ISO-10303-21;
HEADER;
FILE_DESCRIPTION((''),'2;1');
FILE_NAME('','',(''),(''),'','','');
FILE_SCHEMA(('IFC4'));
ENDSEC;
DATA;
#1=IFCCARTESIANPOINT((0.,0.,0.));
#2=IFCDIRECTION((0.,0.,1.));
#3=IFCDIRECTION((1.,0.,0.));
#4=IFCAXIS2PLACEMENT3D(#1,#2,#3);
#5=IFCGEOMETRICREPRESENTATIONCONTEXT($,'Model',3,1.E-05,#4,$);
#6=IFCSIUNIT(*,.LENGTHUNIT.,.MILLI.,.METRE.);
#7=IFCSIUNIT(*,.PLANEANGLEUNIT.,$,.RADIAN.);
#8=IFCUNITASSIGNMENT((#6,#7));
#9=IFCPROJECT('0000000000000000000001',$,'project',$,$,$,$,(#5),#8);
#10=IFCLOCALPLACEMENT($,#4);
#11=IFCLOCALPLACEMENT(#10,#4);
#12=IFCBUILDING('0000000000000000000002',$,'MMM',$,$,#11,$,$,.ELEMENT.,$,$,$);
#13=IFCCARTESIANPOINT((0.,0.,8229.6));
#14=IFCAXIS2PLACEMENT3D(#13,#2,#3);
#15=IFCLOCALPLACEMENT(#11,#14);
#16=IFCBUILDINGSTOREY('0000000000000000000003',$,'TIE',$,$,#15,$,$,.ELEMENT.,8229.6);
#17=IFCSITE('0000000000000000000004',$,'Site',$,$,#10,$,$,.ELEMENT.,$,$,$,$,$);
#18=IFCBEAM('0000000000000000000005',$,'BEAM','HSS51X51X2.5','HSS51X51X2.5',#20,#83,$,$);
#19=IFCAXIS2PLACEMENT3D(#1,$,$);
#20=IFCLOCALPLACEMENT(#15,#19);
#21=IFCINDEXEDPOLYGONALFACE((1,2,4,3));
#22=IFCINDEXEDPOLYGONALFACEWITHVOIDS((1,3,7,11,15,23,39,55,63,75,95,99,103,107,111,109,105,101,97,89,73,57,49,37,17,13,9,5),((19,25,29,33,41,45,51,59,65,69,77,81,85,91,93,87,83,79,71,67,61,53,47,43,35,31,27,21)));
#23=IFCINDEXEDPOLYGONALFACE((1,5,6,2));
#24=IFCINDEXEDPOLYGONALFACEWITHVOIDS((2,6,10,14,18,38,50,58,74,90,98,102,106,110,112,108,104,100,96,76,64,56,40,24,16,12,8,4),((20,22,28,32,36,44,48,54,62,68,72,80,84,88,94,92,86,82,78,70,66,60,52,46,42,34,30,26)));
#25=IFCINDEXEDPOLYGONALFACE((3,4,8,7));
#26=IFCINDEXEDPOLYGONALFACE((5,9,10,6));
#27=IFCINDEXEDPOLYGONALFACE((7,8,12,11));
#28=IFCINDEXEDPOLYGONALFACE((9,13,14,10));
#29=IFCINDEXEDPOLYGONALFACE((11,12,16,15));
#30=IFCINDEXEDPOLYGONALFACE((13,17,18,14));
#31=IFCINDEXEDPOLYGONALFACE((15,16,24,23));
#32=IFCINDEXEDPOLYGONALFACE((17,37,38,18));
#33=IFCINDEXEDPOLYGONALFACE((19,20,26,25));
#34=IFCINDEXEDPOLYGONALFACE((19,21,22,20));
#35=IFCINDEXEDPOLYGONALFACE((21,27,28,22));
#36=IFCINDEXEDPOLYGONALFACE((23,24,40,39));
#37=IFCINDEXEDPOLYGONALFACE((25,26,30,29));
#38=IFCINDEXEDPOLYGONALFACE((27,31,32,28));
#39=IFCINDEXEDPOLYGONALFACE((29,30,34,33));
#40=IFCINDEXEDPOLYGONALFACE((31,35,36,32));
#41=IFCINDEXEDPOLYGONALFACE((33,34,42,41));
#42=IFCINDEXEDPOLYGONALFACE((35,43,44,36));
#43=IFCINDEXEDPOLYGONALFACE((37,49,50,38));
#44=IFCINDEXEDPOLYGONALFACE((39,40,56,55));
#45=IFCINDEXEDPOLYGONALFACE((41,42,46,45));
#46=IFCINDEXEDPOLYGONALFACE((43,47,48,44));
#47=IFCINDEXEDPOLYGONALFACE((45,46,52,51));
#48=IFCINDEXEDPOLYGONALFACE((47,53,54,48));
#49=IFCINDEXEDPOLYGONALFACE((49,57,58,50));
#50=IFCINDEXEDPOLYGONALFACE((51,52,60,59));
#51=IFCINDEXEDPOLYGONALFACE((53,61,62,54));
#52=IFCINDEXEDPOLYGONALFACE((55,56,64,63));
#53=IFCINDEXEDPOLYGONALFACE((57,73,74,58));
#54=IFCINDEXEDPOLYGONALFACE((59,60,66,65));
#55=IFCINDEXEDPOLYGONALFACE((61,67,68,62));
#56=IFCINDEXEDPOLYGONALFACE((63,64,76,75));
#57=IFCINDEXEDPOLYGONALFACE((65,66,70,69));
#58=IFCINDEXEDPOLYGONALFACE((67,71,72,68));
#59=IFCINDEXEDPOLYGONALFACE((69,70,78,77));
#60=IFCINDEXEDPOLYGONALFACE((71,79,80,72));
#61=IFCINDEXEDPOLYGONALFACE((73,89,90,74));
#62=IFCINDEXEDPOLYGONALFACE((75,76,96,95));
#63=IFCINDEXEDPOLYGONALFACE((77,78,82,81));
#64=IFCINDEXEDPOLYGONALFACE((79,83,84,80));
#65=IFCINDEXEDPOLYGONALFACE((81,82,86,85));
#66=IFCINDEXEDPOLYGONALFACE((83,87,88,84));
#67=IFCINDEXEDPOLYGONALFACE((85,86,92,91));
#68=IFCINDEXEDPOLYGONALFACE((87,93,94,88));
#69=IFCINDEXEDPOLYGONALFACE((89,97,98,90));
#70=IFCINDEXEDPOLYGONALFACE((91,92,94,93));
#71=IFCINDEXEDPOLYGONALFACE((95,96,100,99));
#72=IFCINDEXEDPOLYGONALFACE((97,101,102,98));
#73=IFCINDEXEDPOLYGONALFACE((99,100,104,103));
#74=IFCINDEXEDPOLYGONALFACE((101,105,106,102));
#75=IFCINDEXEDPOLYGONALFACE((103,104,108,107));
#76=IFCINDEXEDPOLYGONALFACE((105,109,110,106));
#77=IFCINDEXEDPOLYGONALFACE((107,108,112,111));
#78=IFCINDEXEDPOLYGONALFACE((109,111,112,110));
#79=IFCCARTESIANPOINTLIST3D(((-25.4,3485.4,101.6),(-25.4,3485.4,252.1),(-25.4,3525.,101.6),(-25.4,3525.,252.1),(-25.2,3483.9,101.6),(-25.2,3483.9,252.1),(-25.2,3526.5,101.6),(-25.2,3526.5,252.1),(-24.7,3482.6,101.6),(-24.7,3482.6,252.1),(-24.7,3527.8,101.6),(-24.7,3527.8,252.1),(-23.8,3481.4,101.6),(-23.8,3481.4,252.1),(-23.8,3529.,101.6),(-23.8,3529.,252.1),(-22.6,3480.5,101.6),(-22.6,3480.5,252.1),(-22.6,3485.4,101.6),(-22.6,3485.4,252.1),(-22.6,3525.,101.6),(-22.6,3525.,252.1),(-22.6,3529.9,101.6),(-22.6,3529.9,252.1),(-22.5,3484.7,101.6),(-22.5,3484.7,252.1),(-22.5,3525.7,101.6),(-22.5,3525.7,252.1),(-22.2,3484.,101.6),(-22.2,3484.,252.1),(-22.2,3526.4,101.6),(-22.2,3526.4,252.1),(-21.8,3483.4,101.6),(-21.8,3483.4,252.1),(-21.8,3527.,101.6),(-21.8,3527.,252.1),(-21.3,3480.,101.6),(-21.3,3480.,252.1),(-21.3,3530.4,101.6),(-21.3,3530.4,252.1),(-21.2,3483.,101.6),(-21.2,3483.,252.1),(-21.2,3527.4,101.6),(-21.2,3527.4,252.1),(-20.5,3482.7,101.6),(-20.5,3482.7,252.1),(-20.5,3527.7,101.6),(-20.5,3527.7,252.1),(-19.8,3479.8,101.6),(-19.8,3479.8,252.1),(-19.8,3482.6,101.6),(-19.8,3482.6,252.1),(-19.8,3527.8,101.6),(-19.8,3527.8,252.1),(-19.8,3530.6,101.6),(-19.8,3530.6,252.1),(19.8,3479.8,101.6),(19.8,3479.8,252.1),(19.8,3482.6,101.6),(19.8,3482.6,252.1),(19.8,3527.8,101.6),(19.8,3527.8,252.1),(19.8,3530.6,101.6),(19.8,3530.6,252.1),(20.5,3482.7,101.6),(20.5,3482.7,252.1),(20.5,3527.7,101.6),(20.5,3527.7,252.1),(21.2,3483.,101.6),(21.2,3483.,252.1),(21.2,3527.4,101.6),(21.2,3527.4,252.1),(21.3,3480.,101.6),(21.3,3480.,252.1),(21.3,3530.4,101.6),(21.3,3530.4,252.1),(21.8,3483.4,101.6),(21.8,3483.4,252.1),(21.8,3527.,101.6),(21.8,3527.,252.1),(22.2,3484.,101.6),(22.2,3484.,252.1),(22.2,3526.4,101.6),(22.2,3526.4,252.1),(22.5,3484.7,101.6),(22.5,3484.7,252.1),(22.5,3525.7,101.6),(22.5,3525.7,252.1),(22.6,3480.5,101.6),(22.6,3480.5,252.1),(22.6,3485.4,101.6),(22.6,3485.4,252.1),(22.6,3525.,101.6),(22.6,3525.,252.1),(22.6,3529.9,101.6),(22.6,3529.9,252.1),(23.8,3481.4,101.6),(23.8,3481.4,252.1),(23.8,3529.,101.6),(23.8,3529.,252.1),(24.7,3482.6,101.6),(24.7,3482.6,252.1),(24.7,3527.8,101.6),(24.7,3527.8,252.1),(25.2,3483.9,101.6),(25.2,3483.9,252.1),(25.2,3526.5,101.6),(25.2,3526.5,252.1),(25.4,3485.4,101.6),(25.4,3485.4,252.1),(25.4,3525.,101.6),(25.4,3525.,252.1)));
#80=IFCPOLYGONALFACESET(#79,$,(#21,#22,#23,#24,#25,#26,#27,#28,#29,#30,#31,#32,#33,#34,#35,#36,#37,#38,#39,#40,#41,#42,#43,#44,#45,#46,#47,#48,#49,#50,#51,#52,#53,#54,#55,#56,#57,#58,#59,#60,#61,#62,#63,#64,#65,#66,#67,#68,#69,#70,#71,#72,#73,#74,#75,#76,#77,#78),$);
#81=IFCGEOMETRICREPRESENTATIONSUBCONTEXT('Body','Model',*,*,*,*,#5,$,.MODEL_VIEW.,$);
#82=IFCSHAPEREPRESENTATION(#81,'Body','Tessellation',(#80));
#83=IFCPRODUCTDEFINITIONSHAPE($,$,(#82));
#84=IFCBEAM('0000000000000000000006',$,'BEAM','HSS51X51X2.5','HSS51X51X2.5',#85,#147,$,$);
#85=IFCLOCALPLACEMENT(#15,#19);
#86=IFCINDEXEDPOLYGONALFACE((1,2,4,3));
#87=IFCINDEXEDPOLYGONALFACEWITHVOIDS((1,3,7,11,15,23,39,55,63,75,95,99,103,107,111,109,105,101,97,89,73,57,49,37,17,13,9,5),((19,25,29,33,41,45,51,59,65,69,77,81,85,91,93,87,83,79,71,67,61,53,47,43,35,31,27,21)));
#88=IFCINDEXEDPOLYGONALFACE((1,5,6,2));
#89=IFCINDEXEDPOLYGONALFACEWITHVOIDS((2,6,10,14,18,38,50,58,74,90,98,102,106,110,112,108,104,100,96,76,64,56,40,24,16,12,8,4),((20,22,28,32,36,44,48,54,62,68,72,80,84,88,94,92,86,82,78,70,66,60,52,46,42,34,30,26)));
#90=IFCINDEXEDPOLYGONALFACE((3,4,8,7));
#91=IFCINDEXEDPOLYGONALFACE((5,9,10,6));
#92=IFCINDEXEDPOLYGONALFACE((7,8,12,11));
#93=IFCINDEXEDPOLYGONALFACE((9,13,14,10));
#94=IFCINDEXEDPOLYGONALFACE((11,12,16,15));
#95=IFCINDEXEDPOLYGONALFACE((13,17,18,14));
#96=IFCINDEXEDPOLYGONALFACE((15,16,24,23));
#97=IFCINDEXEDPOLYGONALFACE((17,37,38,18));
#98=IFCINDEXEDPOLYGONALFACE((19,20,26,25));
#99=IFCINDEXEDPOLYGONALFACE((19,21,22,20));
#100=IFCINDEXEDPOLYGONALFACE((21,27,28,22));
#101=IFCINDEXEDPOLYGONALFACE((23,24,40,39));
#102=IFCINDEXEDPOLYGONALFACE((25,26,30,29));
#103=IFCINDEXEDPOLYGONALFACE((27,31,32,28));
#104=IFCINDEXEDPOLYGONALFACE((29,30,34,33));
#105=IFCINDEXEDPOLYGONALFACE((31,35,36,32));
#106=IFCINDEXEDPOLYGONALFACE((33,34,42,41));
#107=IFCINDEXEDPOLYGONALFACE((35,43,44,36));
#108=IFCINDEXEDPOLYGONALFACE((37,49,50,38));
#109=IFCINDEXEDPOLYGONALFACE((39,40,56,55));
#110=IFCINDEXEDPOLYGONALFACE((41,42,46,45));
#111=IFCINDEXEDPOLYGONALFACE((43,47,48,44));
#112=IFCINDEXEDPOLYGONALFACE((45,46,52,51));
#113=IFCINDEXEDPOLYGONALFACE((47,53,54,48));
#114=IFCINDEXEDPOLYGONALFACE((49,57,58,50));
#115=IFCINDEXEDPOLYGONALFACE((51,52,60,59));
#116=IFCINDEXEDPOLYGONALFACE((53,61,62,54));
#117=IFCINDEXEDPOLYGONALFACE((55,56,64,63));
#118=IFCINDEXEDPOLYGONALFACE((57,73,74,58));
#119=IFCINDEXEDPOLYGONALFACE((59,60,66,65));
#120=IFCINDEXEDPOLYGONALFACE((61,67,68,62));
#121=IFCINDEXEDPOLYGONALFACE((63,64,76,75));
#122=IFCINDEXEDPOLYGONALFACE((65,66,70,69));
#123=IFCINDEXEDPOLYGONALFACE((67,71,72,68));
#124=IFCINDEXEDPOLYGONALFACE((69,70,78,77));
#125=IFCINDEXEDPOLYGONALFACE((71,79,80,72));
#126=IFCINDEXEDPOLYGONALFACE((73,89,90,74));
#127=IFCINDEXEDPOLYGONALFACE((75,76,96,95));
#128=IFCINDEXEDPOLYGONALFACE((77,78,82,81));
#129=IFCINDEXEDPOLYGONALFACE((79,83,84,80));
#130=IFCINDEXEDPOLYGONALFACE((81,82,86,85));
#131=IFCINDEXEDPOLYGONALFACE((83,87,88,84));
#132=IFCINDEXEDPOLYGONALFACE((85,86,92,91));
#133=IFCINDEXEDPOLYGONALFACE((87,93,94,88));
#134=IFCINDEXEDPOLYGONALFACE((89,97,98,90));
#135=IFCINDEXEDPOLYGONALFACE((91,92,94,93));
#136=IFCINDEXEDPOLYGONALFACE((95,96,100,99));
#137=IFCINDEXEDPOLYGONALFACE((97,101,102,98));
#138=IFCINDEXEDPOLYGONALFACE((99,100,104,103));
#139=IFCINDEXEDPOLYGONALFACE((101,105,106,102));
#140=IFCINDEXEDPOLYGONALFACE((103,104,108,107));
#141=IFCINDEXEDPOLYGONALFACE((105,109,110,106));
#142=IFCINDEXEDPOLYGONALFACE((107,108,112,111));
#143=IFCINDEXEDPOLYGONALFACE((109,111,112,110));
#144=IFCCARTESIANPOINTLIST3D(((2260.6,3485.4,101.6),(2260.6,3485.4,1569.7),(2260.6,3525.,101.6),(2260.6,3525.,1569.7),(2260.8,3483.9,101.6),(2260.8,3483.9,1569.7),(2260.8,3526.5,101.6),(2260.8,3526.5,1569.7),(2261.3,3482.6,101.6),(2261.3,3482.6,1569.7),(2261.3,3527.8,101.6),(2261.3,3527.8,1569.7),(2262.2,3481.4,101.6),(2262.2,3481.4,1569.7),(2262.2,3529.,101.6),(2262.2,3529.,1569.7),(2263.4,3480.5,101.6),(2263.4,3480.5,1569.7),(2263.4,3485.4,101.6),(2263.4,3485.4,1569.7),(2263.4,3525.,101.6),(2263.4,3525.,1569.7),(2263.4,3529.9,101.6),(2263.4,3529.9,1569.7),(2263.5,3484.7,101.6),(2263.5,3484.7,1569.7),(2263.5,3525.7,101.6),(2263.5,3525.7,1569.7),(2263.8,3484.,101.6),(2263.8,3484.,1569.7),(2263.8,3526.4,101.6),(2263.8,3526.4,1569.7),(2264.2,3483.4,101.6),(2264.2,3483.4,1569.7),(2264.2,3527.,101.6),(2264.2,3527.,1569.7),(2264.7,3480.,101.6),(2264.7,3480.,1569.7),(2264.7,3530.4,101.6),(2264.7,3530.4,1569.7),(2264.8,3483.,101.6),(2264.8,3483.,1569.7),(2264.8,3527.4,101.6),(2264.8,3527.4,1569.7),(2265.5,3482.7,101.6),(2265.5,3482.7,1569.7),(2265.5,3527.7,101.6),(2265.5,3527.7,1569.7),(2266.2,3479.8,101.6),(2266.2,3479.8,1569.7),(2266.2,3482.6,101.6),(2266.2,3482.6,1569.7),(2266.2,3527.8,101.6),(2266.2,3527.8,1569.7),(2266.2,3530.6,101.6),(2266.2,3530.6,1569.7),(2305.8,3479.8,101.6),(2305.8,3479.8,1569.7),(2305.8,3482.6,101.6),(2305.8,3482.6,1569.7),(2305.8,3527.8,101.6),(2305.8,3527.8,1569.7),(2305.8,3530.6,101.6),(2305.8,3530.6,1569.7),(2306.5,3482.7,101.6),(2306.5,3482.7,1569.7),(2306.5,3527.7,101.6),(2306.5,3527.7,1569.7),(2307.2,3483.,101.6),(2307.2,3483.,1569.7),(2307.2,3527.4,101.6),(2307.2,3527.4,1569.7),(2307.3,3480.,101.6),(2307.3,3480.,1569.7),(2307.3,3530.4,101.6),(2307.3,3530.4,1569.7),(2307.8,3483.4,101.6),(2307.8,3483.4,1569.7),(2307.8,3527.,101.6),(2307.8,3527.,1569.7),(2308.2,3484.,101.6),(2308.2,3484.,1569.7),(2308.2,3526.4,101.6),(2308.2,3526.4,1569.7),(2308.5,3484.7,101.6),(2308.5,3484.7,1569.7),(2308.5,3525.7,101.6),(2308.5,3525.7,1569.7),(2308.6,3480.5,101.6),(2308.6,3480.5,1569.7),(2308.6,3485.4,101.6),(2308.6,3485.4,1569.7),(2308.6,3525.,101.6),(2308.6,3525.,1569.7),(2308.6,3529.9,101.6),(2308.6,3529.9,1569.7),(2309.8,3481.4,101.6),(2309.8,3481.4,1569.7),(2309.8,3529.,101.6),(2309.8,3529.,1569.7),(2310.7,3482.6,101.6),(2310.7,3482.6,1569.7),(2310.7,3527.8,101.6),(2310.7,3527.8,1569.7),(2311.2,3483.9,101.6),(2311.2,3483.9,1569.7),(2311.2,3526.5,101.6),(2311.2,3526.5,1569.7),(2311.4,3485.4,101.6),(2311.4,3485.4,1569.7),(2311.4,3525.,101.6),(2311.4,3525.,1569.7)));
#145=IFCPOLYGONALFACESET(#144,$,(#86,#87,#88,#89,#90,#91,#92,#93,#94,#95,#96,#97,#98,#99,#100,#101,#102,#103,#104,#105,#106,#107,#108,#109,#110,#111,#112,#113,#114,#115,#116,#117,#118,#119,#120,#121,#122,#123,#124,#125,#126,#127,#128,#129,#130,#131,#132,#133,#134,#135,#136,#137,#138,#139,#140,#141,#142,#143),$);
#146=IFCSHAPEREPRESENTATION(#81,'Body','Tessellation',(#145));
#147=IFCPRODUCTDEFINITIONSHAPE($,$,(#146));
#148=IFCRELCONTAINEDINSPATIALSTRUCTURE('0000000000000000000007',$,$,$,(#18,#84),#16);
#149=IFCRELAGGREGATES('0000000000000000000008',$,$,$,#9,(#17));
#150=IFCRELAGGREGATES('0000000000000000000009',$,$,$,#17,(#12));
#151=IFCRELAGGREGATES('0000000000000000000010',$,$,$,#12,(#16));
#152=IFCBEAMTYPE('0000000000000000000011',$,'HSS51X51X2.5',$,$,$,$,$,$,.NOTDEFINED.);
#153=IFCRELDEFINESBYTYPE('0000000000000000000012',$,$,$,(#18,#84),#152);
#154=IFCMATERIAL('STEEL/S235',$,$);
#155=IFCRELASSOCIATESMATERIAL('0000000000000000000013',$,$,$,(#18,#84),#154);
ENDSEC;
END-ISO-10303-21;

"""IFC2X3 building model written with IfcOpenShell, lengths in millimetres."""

from ifc_helpers import new_model, si_unit, frame, origin_with_axes, origin_2d_with_axis, place, context, subcontext, project, spatial, hollow_rectangle, extrude, material, type_object, element, save


model = new_model("IFC2X3")

# Units and contexts
model_context = context("Model", 3, precision=1e-05, world=origin_with_axes())
body_context = subcontext(model_context, "Body", "Model", "MODEL_VIEW")
ifc_project = project(units=[si_unit("LENGTHUNIT", "METRE", prefix="MILLI"), si_unit("PLANEANGLEUNIT", "RADIAN")], contexts=[model_context])

# Site, building, storey
site_placement = place(None, origin_with_axes())
site = spatial("IfcSite", under=ifc_project, at=site_placement, Name="Site", CompositionType="ELEMENT")
building_placement = place(site_placement, origin_with_axes())
building = spatial("IfcBuilding", under=site, at=building_placement, Name="MMM", CompositionType="ELEMENT")
storey_placement = place(building_placement, frame((0.0, 0.0, 8229.6), z_axis=(0.0, 0.0, 1.0), x_axis=(1.0, 0.0, 0.0)))
storey = spatial("IfcBuildingStorey", under=building, at=storey_placement, Name="TIE", CompositionType="ELEMENT", Elevation=8229.6)

# Beams
ifc_material = material(Name="STEEL/S235")
beam_type_1 = type_object("IfcBeamType", Name="HSS51X51X2.5", PredefinedType="NOTDEFINED")
beam_1_placement = place(storey_placement, frame((0.0, 3505.2, 252.1), z_axis=(1.0, 0.0, 0.0), x_axis=(0.0, 0.0, -1.0)))
element("IfcBeam", 1, at=beam_1_placement, inside=storey, type_object=beam_type_1, material=ifc_material, Name="BEAM", Description="HSS51X51X2.5", ObjectType="HSS51X51X2.5", context=body_context, shape_type="SweptSolid", body=[
    extrude(hollow_rectangle(XDim=50.8, YDim=50.8, WallThickness=2.8, InnerFilletRadius=2.8, OuterFilletRadius=5.6, at=origin_2d_with_axis()), frame((150.5, 0.0, 0.0), z_axis=(-1.0, 0.0, 0.0), x_axis=(0.0, -1.0, 0.0)), (0.0, 0.0, 1.0), 150.5),
])
beam_2_placement = place(storey_placement, frame((2286.0, 3505.2, 1569.7), z_axis=(1.0, 0.0, 0.0), x_axis=(0.0, 0.0, -1.0)))
element("IfcBeam", 2, at=beam_2_placement, inside=storey, type_object=beam_type_1, material=ifc_material, Name="BEAM", Description="HSS51X51X2.5", ObjectType="HSS51X51X2.5", context=body_context, shape_type="SweptSolid", body=[
    extrude(hollow_rectangle(XDim=50.8, YDim=50.8, WallThickness=2.8, InnerFilletRadius=2.8, OuterFilletRadius=5.6, at=origin_2d_with_axis()), frame((1468.1, 0.0, 0.0), z_axis=(-1.0, 0.0, 0.0), x_axis=(0.0, -1.0, 0.0)), (0.0, 0.0, 1.0), 1468.1),
])

save(model, "model.ifc")
